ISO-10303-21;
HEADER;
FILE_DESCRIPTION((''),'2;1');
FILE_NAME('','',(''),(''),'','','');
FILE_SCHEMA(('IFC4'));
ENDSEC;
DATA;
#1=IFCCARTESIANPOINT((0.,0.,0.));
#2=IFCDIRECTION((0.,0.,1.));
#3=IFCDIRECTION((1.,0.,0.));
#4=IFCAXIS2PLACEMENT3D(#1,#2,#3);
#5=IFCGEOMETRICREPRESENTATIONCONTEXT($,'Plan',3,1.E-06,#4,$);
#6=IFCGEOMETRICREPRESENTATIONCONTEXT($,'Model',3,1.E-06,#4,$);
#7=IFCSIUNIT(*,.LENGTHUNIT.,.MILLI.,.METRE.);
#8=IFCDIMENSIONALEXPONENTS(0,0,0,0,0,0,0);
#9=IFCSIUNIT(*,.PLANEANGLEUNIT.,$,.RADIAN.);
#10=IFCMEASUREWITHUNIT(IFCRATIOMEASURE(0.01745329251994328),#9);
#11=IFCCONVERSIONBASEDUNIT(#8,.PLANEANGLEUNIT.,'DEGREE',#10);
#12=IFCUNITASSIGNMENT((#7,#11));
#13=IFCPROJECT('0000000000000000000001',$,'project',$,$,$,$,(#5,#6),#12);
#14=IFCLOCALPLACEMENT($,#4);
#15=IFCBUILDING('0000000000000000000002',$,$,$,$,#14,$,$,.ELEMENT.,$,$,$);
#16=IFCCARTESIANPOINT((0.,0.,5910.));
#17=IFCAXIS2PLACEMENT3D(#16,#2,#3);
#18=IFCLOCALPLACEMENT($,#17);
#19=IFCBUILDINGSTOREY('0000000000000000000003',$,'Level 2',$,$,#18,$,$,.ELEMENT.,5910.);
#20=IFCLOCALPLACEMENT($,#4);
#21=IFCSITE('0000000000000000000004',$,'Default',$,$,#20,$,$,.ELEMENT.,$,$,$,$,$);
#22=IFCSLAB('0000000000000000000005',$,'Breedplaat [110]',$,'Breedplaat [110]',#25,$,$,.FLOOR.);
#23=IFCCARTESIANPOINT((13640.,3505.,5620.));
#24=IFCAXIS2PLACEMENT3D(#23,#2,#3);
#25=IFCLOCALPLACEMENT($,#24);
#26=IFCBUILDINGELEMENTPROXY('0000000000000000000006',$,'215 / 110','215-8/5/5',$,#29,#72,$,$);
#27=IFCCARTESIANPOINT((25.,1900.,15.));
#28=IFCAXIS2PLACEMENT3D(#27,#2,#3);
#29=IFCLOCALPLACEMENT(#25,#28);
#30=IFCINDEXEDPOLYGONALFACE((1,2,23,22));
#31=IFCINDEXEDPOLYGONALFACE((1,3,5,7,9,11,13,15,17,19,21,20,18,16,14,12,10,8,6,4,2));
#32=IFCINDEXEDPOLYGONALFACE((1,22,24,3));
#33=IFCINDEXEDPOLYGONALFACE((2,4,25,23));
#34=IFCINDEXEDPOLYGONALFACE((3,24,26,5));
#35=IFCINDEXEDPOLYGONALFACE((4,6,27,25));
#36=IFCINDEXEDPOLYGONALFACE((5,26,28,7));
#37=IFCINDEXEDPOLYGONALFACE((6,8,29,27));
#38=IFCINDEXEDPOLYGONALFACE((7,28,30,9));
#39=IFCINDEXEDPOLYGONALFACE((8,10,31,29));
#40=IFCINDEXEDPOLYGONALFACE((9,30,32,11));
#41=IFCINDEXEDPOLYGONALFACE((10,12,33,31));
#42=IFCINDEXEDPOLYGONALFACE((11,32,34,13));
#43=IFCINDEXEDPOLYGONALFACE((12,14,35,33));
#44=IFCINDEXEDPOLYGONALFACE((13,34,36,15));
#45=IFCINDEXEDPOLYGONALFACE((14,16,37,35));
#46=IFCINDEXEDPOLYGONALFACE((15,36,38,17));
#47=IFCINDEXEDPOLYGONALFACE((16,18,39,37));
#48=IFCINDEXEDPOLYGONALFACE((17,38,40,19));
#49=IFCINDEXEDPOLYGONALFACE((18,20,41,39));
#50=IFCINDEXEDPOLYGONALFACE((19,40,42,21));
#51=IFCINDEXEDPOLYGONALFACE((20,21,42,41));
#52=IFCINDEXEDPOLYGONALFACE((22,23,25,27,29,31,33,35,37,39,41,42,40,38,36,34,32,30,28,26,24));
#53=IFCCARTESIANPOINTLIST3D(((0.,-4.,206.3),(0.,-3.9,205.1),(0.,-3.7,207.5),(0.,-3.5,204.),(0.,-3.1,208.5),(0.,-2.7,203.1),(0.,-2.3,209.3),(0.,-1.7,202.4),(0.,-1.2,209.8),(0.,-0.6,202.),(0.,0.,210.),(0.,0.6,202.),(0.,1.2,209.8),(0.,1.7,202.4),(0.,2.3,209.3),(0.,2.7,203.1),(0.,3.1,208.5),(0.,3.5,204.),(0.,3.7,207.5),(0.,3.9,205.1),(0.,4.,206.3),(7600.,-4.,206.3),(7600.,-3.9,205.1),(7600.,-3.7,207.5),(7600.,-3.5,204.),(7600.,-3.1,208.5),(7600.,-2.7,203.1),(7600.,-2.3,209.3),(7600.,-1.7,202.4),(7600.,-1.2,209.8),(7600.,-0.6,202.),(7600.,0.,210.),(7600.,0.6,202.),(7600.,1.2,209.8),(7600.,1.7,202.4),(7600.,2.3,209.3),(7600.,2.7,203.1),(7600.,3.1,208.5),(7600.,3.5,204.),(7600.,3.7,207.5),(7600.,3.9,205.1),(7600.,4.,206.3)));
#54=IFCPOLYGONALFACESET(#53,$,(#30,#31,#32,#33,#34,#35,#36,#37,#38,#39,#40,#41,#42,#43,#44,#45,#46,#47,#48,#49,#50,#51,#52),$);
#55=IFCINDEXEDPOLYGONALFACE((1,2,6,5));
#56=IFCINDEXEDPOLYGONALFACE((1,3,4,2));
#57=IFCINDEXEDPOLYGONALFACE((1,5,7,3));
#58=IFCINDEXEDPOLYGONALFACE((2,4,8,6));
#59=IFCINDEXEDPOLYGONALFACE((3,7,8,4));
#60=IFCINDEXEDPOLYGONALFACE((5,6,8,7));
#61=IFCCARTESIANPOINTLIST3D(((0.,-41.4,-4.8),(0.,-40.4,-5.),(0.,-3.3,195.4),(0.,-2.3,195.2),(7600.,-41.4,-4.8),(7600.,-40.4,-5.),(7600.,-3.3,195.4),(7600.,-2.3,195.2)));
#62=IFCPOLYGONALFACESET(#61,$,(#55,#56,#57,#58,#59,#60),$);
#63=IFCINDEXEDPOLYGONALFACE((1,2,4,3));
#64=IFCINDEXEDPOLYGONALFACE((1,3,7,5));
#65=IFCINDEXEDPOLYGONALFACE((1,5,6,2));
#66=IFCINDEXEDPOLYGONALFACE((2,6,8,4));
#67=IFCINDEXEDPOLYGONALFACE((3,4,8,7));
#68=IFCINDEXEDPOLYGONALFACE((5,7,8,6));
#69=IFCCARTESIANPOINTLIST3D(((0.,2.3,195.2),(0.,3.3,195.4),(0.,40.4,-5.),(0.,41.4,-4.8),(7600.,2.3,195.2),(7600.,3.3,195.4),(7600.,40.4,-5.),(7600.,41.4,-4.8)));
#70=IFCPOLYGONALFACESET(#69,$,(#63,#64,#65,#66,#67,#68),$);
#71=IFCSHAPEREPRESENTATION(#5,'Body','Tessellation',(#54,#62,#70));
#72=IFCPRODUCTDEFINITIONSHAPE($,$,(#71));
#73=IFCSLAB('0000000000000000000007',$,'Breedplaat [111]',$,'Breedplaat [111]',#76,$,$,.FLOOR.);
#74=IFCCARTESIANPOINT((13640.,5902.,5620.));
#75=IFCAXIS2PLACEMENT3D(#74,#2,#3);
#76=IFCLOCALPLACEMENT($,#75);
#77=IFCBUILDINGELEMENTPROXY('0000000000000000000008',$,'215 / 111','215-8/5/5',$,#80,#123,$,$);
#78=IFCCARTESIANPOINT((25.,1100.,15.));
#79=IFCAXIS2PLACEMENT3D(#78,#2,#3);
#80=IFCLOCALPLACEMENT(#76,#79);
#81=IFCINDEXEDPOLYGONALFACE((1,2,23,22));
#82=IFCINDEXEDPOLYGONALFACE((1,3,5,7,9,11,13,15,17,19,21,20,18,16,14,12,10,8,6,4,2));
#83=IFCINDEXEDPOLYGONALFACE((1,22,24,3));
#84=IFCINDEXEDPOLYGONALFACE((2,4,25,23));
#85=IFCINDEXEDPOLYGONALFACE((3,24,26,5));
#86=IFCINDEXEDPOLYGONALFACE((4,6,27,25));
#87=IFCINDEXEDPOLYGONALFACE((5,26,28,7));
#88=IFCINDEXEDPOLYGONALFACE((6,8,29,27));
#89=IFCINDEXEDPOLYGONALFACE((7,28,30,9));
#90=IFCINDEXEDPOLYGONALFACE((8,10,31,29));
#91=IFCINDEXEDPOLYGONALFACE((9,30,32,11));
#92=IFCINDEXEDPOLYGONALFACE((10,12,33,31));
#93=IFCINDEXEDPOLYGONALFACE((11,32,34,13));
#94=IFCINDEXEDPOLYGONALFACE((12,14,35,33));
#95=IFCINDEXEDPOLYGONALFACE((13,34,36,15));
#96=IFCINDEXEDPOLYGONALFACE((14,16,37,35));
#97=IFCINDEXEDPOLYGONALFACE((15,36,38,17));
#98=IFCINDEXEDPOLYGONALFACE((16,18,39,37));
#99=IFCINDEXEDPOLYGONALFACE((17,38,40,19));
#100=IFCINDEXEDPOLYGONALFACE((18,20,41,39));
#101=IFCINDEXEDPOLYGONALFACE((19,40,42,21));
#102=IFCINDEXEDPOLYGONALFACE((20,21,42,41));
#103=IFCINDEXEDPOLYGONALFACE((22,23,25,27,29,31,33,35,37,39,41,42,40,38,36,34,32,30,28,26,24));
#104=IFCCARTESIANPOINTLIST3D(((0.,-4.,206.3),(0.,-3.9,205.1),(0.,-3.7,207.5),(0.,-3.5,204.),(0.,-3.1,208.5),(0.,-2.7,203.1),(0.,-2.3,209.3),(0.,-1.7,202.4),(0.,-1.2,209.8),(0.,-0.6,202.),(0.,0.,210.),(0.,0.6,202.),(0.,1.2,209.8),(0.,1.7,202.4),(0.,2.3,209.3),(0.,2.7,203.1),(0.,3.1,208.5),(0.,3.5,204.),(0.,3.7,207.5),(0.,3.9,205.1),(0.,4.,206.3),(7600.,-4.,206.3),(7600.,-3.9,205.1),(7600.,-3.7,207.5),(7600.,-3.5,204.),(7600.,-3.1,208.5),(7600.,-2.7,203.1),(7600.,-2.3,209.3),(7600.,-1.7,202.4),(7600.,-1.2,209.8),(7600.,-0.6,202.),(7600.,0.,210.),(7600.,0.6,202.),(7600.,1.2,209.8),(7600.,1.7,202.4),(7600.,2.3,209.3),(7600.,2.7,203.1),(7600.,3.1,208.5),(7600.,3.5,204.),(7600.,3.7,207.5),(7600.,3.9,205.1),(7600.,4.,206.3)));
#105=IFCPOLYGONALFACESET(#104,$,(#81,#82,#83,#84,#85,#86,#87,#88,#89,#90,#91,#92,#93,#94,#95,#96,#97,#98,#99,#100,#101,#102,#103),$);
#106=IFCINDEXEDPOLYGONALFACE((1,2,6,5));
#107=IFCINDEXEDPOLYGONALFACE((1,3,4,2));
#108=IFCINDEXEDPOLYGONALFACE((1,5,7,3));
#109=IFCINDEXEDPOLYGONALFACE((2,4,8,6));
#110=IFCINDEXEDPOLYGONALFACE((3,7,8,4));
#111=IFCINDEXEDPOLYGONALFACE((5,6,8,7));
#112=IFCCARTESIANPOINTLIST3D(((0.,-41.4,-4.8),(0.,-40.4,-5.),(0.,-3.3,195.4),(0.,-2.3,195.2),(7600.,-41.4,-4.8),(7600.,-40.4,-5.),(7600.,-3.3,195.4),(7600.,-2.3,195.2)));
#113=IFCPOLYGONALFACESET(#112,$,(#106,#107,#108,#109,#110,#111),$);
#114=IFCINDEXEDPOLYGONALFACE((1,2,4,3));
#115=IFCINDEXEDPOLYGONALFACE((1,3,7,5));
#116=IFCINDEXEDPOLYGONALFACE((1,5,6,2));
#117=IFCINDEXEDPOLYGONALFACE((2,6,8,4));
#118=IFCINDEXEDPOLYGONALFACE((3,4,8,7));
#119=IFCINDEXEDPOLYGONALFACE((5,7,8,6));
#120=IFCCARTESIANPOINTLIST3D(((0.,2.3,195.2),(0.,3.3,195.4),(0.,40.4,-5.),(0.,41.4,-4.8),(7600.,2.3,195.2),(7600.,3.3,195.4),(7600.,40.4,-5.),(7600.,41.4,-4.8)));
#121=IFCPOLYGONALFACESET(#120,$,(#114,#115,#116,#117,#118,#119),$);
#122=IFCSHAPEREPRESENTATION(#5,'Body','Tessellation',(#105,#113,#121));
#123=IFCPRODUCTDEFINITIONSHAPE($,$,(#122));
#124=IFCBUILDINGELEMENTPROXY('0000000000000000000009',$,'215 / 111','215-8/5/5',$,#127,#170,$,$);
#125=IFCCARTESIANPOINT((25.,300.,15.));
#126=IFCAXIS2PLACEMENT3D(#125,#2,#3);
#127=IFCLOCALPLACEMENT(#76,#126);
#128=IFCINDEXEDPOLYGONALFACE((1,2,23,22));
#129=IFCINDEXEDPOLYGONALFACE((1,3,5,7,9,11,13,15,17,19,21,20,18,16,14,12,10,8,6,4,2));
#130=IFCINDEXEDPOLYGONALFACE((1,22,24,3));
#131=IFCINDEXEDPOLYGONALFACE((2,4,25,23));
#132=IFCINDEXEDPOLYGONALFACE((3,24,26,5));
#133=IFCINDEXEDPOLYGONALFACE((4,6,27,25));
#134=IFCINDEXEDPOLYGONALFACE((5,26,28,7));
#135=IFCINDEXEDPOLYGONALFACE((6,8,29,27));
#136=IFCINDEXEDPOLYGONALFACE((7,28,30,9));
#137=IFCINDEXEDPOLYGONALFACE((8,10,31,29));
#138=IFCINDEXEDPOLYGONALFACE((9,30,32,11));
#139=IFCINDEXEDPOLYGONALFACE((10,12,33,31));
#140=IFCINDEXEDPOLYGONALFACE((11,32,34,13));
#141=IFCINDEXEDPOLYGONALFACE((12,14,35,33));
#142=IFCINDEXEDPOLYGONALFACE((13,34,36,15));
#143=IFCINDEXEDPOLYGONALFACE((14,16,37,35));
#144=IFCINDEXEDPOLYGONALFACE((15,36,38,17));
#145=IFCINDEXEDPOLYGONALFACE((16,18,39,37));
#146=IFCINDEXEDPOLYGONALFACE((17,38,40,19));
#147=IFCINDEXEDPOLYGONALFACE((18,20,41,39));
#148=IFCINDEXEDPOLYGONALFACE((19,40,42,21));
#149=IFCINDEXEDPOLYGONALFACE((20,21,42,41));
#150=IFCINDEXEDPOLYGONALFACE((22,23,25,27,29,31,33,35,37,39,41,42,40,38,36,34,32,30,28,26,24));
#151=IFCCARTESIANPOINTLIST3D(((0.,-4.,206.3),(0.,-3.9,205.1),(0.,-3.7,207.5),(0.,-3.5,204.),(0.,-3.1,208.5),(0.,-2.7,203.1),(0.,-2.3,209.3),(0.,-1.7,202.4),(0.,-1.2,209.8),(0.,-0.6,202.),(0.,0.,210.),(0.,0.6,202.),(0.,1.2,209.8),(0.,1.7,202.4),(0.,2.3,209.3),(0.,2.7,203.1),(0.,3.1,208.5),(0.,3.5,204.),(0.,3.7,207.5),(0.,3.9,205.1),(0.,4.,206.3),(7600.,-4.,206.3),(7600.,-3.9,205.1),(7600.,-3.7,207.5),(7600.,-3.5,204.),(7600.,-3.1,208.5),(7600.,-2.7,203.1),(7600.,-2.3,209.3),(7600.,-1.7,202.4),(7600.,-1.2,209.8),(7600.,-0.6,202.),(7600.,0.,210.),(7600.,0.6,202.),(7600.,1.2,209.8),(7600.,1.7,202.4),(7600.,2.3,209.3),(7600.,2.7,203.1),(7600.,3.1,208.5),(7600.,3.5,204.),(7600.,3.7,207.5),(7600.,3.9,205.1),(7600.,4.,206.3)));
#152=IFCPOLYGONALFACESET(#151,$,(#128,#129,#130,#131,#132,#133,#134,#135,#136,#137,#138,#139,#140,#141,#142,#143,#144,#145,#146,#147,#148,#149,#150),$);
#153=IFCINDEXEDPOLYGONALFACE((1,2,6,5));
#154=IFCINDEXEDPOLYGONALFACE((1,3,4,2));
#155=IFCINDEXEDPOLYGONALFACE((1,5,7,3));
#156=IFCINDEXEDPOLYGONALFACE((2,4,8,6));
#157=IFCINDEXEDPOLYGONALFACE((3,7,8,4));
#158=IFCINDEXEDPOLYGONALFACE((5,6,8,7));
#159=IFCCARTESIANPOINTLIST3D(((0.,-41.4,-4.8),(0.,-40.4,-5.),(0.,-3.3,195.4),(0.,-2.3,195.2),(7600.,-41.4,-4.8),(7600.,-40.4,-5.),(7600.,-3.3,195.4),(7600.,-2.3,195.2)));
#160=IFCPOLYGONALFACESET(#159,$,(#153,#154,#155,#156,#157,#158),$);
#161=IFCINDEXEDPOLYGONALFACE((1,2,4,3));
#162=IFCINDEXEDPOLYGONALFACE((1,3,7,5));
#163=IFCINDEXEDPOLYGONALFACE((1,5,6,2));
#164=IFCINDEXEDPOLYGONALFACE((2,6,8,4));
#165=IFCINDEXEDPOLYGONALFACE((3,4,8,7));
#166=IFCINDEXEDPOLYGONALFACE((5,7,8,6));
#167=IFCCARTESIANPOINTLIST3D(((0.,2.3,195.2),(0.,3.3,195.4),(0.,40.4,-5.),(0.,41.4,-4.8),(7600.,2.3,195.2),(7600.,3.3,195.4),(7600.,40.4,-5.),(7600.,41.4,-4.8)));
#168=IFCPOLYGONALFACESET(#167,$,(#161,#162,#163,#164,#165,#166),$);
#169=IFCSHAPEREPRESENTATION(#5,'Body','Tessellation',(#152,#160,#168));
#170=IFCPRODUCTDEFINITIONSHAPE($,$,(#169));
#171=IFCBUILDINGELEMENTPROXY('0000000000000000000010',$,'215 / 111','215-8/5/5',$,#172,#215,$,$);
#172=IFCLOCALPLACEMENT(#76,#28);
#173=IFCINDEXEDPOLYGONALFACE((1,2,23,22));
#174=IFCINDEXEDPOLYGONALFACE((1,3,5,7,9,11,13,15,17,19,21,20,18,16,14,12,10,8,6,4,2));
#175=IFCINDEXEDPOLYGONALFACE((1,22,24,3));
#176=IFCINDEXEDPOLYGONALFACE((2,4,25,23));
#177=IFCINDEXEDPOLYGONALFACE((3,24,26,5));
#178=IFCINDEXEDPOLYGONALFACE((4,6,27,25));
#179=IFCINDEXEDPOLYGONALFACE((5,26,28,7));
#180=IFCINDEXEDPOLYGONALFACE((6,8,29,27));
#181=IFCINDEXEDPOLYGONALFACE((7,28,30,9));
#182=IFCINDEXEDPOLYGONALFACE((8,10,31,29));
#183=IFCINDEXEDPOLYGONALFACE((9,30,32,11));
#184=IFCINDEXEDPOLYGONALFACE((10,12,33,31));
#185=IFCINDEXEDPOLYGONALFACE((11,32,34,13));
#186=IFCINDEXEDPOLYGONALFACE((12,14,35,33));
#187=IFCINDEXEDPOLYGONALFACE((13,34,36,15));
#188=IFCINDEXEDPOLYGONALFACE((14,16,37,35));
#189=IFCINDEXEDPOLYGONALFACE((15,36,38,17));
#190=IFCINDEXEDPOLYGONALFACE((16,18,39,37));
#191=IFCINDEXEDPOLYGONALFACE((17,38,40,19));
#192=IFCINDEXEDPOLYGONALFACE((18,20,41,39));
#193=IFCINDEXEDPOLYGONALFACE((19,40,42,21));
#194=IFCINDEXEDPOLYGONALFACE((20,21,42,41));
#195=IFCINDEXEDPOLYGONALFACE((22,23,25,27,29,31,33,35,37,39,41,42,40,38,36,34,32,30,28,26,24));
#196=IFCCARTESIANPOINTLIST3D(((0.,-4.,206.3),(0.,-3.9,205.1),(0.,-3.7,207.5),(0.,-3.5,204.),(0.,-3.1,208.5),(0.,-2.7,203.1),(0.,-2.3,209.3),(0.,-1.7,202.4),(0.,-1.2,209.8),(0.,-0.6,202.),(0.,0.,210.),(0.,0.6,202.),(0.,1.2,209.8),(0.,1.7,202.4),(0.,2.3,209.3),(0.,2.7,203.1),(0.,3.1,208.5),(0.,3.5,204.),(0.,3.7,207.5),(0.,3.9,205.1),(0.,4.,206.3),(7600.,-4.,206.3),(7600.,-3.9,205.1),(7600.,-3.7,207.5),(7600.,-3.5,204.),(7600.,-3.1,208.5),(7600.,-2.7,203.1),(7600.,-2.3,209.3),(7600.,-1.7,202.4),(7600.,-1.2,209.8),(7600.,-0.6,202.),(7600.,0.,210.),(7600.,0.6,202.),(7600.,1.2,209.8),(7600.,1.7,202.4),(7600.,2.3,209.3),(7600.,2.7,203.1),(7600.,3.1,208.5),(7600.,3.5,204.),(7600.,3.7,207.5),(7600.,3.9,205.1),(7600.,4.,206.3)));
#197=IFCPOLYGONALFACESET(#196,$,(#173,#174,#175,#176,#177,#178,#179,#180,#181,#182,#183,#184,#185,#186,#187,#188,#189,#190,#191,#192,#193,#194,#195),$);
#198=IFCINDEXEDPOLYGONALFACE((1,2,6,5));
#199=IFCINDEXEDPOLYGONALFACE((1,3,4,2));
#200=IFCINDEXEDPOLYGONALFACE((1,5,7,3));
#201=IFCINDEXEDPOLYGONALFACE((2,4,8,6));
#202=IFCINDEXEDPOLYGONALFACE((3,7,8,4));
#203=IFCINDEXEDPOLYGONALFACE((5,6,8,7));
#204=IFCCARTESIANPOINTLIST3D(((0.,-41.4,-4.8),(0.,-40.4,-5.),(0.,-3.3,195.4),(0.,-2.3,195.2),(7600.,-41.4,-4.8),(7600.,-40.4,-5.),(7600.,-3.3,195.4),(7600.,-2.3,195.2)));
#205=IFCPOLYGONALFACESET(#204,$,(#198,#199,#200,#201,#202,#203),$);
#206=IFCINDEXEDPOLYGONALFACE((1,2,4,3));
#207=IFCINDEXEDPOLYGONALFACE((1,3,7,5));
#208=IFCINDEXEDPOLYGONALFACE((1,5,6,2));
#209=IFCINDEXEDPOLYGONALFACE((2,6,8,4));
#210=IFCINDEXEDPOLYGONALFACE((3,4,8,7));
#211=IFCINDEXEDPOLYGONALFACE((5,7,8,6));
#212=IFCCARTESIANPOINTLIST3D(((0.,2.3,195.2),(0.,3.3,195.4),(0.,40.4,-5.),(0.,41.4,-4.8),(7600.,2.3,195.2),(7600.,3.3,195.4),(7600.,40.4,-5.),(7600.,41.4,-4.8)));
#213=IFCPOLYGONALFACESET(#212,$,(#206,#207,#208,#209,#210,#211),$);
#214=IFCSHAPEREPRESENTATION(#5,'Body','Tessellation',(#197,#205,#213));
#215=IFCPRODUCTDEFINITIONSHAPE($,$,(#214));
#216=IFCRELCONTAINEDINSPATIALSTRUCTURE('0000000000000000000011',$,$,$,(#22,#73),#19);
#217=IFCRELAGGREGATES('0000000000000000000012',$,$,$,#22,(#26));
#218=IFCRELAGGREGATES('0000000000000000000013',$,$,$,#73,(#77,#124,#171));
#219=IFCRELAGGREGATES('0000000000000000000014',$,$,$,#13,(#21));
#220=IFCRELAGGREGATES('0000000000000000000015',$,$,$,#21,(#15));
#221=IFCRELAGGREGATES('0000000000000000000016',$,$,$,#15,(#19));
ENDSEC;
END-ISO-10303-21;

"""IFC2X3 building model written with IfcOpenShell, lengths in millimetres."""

from ifc_helpers import new_model, entity, si_unit, converted_unit, frame, origin_with_axes, origin_2d_with_axis, place, context, project, spatial, rectangle, circle, extrude, element, aggregate, save


model = new_model("IFC2X3")

# Units and contexts
plan_context = context("Plan", 3, precision=1e-06, world=origin_with_axes())
model_context = context("Model", 3, precision=1e-06, world=origin_with_axes())
ifc_project = project(units=[si_unit("LENGTHUNIT", "METRE", prefix="MILLI"), converted_unit("PLANEANGLEUNIT", "DEGREE", entity("IfcRatioMeasure", 0.01745329251994328), si_unit("PLANEANGLEUNIT", "RADIAN"), dimensions=[0, 0, 0, 0, 0, 0, 0])], contexts=[plan_context, model_context])

# Site, building, storey
site_placement = place(None, origin_with_axes())
site = spatial("IfcSite", under=ifc_project, at=site_placement, Name="Default", CompositionType="ELEMENT")
building_placement = place(None, origin_with_axes())
building = spatial("IfcBuilding", under=site, at=building_placement, CompositionType="ELEMENT")
storey_placement = place(None, frame((0.0, 0.0, 5910.0), z_axis=(0.0, 0.0, 1.0), x_axis=(1.0, 0.0, 0.0)))
storey = spatial("IfcBuildingStorey", under=building, at=storey_placement, Name="Level 2", CompositionType="ELEMENT", Elevation=5910.0)

# Slab, building element proxy
slab_1_placement = place(None, frame((13640.0, 3505.0, 5620.0), z_axis=(0.0, 0.0, 1.0), x_axis=(1.0, 0.0, 0.0)))
slab_1 = element("IfcSlab", 1, at=slab_1_placement, inside=storey, Name="Breedplaat [110]", ObjectType="Breedplaat [110]", PredefinedType="FLOOR")
proxy_1_placement = place(slab_1_placement, frame((25.0, 1900.0, 15.0), z_axis=(0.0, 0.0, 1.0), x_axis=(1.0, 0.0, 0.0)))
proxy_1 = element("IfcBuildingElementProxy", 2, at=proxy_1_placement, Name="215 / 110", Description="215-8/5/5", context=plan_context, shape_type="SweptSolid", body=[
    extrude(circle(Radius=4.0, at=origin_2d_with_axis()), frame((0.0, 0.0, 206.0), z_axis=(1.0, 0.0, 0.0), x_axis=(0.0, 0.0, 1.0)), (0.0, 0.0, 1.0), 7600.0),
    extrude(rectangle(XDim=203.8, YDim=1.0, at=origin_2d_with_axis()), frame((0.0, -21.9, 95.2), z_axis=(1.0, 0.0, 0.0), x_axis=(0.0, 0.187112, 0.982339)), (0.0, 0.0, 1.0), 7600.0),
    extrude(rectangle(XDim=203.8, YDim=1.0, at=origin_2d_with_axis()), frame((0.0, 21.9, 95.2), z_axis=(1.0, 0.0, 0.0), x_axis=(0.0, -0.187112, 0.982339)), (0.0, 0.0, 1.0), 7600.0),
])
aggregate(slab_1, [proxy_1])

# Slab, building element proxies
slab_2_placement = place(None, frame((13640.0, 5902.0, 5620.0), z_axis=(0.0, 0.0, 1.0), x_axis=(1.0, 0.0, 0.0)))
slab_2 = element("IfcSlab", 3, at=slab_2_placement, inside=storey, Name="Breedplaat [111]", ObjectType="Breedplaat [111]", PredefinedType="FLOOR")
proxy_2_placement = place(slab_2_placement, frame((25.0, 1100.0, 15.0), z_axis=(0.0, 0.0, 1.0), x_axis=(1.0, 0.0, 0.0)))
proxy_2 = element("IfcBuildingElementProxy", 4, at=proxy_2_placement, Name="215 / 111", Description="215-8/5/5", context=plan_context, shape_type="SweptSolid", body=[
    extrude(circle(Radius=4.0, at=origin_2d_with_axis()), frame((0.0, 0.0, 206.0), z_axis=(1.0, 0.0, 0.0), x_axis=(0.0, 0.0, 1.0)), (0.0, 0.0, 1.0), 7600.0),
    extrude(rectangle(XDim=203.8, YDim=1.0, at=origin_2d_with_axis()), frame((0.0, -21.9, 95.2), z_axis=(1.0, 0.0, 0.0), x_axis=(0.0, 0.187112, 0.982339)), (0.0, 0.0, 1.0), 7600.0),
    extrude(rectangle(XDim=203.8, YDim=1.0, at=origin_2d_with_axis()), frame((0.0, 21.9, 95.2), z_axis=(1.0, 0.0, 0.0), x_axis=(0.0, -0.187112, 0.982339)), (0.0, 0.0, 1.0), 7600.0),
])
proxy_3_placement = place(slab_2_placement, frame((25.0, 300.0, 15.0), z_axis=(0.0, 0.0, 1.0), x_axis=(1.0, 0.0, 0.0)))
proxy_3 = element("IfcBuildingElementProxy", 5, at=proxy_3_placement, Name="215 / 111", Description="215-8/5/5", context=plan_context, shape_type="SweptSolid", body=[
    extrude(circle(Radius=4.0, at=origin_2d_with_axis()), frame((0.0, 0.0, 206.0), z_axis=(1.0, 0.0, 0.0), x_axis=(0.0, 0.0, 1.0)), (0.0, 0.0, 1.0), 7600.0),
    extrude(rectangle(XDim=203.8, YDim=1.0, at=origin_2d_with_axis()), frame((0.0, -21.9, 95.2), z_axis=(1.0, 0.0, 0.0), x_axis=(0.0, 0.187112, 0.982339)), (0.0, 0.0, 1.0), 7600.0),
    extrude(rectangle(XDim=203.8, YDim=1.0, at=origin_2d_with_axis()), frame((0.0, 21.9, 95.2), z_axis=(1.0, 0.0, 0.0), x_axis=(0.0, -0.187112, 0.982339)), (0.0, 0.0, 1.0), 7600.0),
])
proxy_4_placement = place(slab_2_placement, frame((25.0, 1900.0, 15.0), z_axis=(0.0, 0.0, 1.0), x_axis=(1.0, 0.0, 0.0)))
proxy_4 = element("IfcBuildingElementProxy", 6, at=proxy_4_placement, Name="215 / 111", Description="215-8/5/5", context=plan_context, shape_type="SweptSolid", body=[
    extrude(circle(Radius=4.0, at=origin_2d_with_axis()), frame((0.0, 0.0, 206.0), z_axis=(1.0, 0.0, 0.0), x_axis=(0.0, 0.0, 1.0)), (0.0, 0.0, 1.0), 7600.0),
    extrude(rectangle(XDim=203.8, YDim=1.0, at=origin_2d_with_axis()), frame((0.0, -21.9, 95.2), z_axis=(1.0, 0.0, 0.0), x_axis=(0.0, 0.187112, 0.982339)), (0.0, 0.0, 1.0), 7600.0),
    extrude(rectangle(XDim=203.8, YDim=1.0, at=origin_2d_with_axis()), frame((0.0, 21.9, 95.2), z_axis=(1.0, 0.0, 0.0), x_axis=(0.0, -0.187112, 0.982339)), (0.0, 0.0, 1.0), 7600.0),
])
aggregate(slab_2, [proxy_2, proxy_3, proxy_4])

save(model, "model.ifc")
